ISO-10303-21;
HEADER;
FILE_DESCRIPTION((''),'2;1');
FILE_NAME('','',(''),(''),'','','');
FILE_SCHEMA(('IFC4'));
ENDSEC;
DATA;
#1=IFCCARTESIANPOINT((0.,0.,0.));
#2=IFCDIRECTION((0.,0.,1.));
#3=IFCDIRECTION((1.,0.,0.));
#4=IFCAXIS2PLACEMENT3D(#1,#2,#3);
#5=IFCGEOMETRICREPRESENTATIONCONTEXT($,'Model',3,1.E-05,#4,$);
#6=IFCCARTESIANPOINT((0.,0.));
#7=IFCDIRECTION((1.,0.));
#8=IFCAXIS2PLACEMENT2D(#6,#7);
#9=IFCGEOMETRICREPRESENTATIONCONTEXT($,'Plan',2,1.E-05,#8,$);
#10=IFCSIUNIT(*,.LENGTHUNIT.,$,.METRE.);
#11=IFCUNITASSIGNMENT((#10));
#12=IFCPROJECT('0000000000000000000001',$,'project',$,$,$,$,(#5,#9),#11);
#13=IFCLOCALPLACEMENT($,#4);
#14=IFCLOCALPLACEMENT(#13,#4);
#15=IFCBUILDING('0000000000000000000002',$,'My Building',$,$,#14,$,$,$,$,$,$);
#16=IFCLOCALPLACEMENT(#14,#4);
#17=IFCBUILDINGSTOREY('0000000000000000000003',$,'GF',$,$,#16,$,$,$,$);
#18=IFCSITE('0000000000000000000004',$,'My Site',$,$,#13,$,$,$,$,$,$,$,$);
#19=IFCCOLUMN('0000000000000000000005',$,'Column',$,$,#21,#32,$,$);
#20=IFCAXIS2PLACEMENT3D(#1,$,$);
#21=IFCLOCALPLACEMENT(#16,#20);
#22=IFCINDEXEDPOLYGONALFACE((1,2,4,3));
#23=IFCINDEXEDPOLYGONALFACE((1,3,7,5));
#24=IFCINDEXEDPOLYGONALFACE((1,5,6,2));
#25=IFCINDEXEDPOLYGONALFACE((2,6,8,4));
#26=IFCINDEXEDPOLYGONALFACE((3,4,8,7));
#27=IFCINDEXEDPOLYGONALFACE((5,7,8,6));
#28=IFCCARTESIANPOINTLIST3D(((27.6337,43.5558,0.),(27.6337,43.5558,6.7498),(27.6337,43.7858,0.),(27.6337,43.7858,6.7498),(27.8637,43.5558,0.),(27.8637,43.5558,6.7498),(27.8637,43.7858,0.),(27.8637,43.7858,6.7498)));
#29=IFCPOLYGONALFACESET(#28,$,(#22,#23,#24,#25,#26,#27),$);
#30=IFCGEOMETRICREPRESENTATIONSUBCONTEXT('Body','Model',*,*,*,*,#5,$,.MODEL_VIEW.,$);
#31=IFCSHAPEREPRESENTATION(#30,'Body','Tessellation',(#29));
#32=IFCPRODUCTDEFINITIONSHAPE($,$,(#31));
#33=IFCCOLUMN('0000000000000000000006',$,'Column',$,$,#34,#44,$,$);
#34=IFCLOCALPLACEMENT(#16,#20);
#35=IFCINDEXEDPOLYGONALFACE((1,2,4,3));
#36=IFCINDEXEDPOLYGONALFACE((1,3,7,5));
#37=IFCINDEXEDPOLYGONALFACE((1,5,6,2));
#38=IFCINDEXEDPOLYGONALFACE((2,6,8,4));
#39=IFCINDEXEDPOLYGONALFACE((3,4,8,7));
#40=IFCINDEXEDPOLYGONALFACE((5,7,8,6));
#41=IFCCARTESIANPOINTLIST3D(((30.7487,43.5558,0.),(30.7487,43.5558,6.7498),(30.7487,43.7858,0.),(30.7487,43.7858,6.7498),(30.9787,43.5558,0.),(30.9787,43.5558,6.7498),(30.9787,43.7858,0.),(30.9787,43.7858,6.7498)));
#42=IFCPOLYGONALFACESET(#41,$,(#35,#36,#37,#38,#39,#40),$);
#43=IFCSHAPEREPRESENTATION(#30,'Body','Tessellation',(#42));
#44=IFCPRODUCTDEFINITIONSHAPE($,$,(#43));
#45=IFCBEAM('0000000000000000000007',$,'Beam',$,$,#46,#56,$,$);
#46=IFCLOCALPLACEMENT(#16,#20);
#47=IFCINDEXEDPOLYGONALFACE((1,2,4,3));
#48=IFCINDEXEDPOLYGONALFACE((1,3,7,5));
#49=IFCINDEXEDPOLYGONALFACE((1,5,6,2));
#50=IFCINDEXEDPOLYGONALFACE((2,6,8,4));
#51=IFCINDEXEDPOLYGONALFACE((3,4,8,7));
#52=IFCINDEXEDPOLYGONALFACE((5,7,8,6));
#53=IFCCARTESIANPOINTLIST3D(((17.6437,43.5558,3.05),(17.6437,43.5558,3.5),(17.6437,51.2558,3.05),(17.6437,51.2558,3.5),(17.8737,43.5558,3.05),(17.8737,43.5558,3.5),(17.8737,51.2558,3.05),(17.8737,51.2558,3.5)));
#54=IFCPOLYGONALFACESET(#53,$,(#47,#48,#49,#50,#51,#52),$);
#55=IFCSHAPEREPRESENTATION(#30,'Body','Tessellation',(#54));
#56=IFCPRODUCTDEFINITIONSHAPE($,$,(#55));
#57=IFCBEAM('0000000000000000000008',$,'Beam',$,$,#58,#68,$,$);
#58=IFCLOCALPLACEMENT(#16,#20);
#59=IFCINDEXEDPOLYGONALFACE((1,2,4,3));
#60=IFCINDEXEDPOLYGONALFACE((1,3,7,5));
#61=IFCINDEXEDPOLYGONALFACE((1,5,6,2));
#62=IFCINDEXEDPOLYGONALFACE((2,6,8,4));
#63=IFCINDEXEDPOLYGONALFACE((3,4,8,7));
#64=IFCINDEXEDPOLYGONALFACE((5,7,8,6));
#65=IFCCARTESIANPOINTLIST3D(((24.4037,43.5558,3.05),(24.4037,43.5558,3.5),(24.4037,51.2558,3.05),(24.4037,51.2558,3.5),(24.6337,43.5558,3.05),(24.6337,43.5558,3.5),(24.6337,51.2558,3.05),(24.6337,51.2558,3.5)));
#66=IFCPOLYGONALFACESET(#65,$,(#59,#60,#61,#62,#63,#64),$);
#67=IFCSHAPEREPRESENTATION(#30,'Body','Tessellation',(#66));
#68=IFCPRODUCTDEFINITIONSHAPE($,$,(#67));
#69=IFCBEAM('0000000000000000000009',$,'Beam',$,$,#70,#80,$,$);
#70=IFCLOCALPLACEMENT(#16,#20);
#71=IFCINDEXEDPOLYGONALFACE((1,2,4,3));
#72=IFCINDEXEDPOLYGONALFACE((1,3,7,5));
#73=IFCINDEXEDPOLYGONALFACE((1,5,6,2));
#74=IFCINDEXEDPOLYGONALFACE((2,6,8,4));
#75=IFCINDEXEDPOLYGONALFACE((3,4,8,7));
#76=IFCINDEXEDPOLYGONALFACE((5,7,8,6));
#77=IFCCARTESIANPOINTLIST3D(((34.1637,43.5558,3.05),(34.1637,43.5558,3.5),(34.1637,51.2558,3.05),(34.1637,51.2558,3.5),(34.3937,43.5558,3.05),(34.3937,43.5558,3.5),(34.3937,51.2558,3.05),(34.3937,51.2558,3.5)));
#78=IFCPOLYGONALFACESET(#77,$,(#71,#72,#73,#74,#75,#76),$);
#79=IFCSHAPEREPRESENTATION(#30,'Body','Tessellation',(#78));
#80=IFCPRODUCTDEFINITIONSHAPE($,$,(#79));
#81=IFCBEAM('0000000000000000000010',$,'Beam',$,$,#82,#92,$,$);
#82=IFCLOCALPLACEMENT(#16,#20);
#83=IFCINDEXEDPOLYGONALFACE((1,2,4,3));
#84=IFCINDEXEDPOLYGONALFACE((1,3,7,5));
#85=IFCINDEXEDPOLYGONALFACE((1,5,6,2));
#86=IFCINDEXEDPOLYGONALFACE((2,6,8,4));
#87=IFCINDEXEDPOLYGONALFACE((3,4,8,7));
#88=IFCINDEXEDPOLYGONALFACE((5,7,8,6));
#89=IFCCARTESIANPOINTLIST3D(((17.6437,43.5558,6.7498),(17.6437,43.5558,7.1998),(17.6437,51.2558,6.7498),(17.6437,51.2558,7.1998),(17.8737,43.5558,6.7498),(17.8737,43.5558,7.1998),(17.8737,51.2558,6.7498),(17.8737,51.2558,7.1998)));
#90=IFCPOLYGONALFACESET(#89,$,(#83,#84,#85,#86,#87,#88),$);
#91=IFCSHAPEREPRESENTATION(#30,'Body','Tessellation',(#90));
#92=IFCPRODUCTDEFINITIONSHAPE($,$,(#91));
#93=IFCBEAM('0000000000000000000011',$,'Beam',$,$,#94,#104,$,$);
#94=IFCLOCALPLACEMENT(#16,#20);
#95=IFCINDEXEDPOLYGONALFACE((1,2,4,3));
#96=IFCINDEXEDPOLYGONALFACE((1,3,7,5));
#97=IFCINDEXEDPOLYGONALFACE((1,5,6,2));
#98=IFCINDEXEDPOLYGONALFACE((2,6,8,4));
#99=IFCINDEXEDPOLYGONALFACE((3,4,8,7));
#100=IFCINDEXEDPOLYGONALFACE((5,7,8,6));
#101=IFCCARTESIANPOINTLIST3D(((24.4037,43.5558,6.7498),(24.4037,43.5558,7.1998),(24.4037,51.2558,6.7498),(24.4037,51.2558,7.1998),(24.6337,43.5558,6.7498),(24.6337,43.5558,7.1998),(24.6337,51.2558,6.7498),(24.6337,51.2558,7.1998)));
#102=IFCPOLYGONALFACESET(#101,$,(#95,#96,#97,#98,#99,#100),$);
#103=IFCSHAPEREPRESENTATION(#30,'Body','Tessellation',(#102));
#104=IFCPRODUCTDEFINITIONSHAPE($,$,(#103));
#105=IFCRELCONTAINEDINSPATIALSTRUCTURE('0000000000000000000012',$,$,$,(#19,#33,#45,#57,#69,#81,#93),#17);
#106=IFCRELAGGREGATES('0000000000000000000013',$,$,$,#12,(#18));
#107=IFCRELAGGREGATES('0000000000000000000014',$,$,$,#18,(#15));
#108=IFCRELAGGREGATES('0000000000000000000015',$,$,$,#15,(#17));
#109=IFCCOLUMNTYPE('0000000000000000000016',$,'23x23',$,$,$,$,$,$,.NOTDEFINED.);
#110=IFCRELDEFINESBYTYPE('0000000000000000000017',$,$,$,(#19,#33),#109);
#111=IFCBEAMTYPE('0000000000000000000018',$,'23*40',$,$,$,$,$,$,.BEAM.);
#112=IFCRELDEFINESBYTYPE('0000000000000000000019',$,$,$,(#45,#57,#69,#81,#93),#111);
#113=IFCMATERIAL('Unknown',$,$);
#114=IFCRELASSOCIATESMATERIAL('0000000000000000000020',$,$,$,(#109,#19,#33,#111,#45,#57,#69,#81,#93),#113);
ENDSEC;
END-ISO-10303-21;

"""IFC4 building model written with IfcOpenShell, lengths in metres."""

from ifc_helpers import new_model, si_unit, frame, origin_with_axes, origin_2d_with_axis, place, context, subcontext, project, spatial, rectangle, extrude, material, material_profile, profile_set, profile_usage, type_object, element, save


model = new_model("IFC4")

# Units and contexts
model_context = context("Model", 3, precision=1e-05, world=origin_with_axes())
plan_context = context("Plan", 2, precision=1e-05, world=origin_2d_with_axis())
body_context = subcontext(model_context, "Body", "Model", "MODEL_VIEW")
ifc_project = project(units=[si_unit("LENGTHUNIT", "METRE")], contexts=[model_context, plan_context])

# Site, building, storey
site_placement = place(None, origin_with_axes())
site = spatial("IfcSite", under=ifc_project, at=site_placement, Name="My Site")
building_placement = place(site_placement, origin_with_axes())
building = spatial("IfcBuilding", under=site, at=building_placement, Name="My Building")
storey_placement = place(building_placement, origin_with_axes())
storey = spatial("IfcBuildingStorey", under=building, at=storey_placement, Name="GF")

# Columns
ifc_material = material(Name="Unknown")
ifc_material_profile_1 = material_profile(ifc_material, rectangle(XDim=0.23, YDim=0.23))
ifc_profile_set_1 = profile_set([ifc_material_profile_1])
column_type_1 = type_object("IfcColumnType", Name="23x23", PredefinedType="NOTDEFINED", material=ifc_profile_set_1)
ifc_profile_usage_1 = profile_usage(ifc_profile_set_1, cardinal=5)
column_1_placement = place(storey_placement, frame((27.7487, 43.6708, 0.0), z_axis=(0.0, 0.0, 1.0), x_axis=(1.0, 0.0, 0.0)))
element("IfcColumn", 1, at=column_1_placement, inside=storey, type_object=column_type_1, material=ifc_profile_usage_1, Name="Column", context=body_context, shape_type="SweptSolid", body=[
    extrude(rectangle(XDim=0.23, YDim=0.23), origin_with_axes(), (0.0, 0.0, 1.0), 6.7498),
])
ifc_profile_usage_2 = profile_usage(ifc_profile_set_1, cardinal=5)
column_2_placement = place(storey_placement, frame((30.8637, 43.6708, 0.0), z_axis=(0.0, 0.0, 1.0), x_axis=(1.0, 0.0, 0.0)))
element("IfcColumn", 2, at=column_2_placement, inside=storey, type_object=column_type_1, material=ifc_profile_usage_2, Name="Column", context=body_context, shape_type="SweptSolid", body=[
    extrude(rectangle(XDim=0.23, YDim=0.23), origin_with_axes(), (0.0, 0.0, 1.0), 6.7498),
])

# Beams
ifc_material_profile_2 = material_profile(ifc_material, rectangle(XDim=0.23, YDim=0.45))
ifc_profile_set_2 = profile_set([ifc_material_profile_2])
ifc_profile_usage_3 = profile_usage(ifc_profile_set_2, cardinal=5)
beam_type = type_object("IfcBeamType", Name="23*40", PredefinedType="BEAM", material=ifc_profile_set_2)
beam_1_placement = place(storey_placement, frame((17.7587, 43.5558, 3.275), z_axis=(0.0, 1.0, 0.0), x_axis=(-1.0, 0.0, 0.0)))
element("IfcBeam", 3, at=beam_1_placement, inside=storey, type_object=beam_type, material=ifc_profile_usage_3, Name="Beam", context=body_context, shape_type="SweptSolid", body=[
    extrude(rectangle(XDim=0.23, YDim=0.45), origin_with_axes(), (0.0, 0.0, 1.0), 7.7),
])
ifc_profile_usage_4 = profile_usage(ifc_profile_set_2, cardinal=5)
beam_2_placement = place(storey_placement, frame((24.5187, 43.5558, 3.275), z_axis=(0.0, 1.0, 0.0), x_axis=(-1.0, 0.0, 0.0)))
element("IfcBeam", 4, at=beam_2_placement, inside=storey, type_object=beam_type, material=ifc_profile_usage_4, Name="Beam", context=body_context, shape_type="SweptSolid", body=[
    extrude(rectangle(XDim=0.23, YDim=0.45), origin_with_axes(), (0.0, 0.0, 1.0), 7.7),
])
ifc_profile_usage_5 = profile_usage(ifc_profile_set_2, cardinal=5)
beam_3_placement = place(storey_placement, frame((34.2787, 43.5558, 3.275), z_axis=(0.0, 1.0, 0.0), x_axis=(-1.0, 0.0, 0.0)))
element("IfcBeam", 5, at=beam_3_placement, inside=storey, type_object=beam_type, material=ifc_profile_usage_5, Name="Beam", context=body_context, shape_type="SweptSolid", body=[
    extrude(rectangle(XDim=0.23, YDim=0.45), origin_with_axes(), (0.0, 0.0, 1.0), 7.7),
])
ifc_profile_usage_6 = profile_usage(ifc_profile_set_2, cardinal=5)
beam_4_placement = place(storey_placement, frame((17.7587, 43.5558, 6.9748), z_axis=(0.0, 1.0, 0.0), x_axis=(-1.0, 0.0, 0.0)))
element("IfcBeam", 6, at=beam_4_placement, inside=storey, type_object=beam_type, material=ifc_profile_usage_6, Name="Beam", context=body_context, shape_type="SweptSolid", body=[
    extrude(rectangle(XDim=0.23, YDim=0.45), origin_with_axes(), (0.0, 0.0, 1.0), 7.7),
])
ifc_profile_usage_7 = profile_usage(ifc_profile_set_2, cardinal=5)
beam_5_placement = place(storey_placement, frame((24.5187, 43.5558, 6.9748), z_axis=(0.0, 1.0, 0.0), x_axis=(-1.0, 0.0, 0.0)))
element("IfcBeam", 7, at=beam_5_placement, inside=storey, type_object=beam_type, material=ifc_profile_usage_7, Name="Beam", context=body_context, shape_type="SweptSolid", body=[
    extrude(rectangle(XDim=0.23, YDim=0.45), origin_with_axes(), (0.0, 0.0, 1.0), 7.7),
])

save(model, "model.ifc")
